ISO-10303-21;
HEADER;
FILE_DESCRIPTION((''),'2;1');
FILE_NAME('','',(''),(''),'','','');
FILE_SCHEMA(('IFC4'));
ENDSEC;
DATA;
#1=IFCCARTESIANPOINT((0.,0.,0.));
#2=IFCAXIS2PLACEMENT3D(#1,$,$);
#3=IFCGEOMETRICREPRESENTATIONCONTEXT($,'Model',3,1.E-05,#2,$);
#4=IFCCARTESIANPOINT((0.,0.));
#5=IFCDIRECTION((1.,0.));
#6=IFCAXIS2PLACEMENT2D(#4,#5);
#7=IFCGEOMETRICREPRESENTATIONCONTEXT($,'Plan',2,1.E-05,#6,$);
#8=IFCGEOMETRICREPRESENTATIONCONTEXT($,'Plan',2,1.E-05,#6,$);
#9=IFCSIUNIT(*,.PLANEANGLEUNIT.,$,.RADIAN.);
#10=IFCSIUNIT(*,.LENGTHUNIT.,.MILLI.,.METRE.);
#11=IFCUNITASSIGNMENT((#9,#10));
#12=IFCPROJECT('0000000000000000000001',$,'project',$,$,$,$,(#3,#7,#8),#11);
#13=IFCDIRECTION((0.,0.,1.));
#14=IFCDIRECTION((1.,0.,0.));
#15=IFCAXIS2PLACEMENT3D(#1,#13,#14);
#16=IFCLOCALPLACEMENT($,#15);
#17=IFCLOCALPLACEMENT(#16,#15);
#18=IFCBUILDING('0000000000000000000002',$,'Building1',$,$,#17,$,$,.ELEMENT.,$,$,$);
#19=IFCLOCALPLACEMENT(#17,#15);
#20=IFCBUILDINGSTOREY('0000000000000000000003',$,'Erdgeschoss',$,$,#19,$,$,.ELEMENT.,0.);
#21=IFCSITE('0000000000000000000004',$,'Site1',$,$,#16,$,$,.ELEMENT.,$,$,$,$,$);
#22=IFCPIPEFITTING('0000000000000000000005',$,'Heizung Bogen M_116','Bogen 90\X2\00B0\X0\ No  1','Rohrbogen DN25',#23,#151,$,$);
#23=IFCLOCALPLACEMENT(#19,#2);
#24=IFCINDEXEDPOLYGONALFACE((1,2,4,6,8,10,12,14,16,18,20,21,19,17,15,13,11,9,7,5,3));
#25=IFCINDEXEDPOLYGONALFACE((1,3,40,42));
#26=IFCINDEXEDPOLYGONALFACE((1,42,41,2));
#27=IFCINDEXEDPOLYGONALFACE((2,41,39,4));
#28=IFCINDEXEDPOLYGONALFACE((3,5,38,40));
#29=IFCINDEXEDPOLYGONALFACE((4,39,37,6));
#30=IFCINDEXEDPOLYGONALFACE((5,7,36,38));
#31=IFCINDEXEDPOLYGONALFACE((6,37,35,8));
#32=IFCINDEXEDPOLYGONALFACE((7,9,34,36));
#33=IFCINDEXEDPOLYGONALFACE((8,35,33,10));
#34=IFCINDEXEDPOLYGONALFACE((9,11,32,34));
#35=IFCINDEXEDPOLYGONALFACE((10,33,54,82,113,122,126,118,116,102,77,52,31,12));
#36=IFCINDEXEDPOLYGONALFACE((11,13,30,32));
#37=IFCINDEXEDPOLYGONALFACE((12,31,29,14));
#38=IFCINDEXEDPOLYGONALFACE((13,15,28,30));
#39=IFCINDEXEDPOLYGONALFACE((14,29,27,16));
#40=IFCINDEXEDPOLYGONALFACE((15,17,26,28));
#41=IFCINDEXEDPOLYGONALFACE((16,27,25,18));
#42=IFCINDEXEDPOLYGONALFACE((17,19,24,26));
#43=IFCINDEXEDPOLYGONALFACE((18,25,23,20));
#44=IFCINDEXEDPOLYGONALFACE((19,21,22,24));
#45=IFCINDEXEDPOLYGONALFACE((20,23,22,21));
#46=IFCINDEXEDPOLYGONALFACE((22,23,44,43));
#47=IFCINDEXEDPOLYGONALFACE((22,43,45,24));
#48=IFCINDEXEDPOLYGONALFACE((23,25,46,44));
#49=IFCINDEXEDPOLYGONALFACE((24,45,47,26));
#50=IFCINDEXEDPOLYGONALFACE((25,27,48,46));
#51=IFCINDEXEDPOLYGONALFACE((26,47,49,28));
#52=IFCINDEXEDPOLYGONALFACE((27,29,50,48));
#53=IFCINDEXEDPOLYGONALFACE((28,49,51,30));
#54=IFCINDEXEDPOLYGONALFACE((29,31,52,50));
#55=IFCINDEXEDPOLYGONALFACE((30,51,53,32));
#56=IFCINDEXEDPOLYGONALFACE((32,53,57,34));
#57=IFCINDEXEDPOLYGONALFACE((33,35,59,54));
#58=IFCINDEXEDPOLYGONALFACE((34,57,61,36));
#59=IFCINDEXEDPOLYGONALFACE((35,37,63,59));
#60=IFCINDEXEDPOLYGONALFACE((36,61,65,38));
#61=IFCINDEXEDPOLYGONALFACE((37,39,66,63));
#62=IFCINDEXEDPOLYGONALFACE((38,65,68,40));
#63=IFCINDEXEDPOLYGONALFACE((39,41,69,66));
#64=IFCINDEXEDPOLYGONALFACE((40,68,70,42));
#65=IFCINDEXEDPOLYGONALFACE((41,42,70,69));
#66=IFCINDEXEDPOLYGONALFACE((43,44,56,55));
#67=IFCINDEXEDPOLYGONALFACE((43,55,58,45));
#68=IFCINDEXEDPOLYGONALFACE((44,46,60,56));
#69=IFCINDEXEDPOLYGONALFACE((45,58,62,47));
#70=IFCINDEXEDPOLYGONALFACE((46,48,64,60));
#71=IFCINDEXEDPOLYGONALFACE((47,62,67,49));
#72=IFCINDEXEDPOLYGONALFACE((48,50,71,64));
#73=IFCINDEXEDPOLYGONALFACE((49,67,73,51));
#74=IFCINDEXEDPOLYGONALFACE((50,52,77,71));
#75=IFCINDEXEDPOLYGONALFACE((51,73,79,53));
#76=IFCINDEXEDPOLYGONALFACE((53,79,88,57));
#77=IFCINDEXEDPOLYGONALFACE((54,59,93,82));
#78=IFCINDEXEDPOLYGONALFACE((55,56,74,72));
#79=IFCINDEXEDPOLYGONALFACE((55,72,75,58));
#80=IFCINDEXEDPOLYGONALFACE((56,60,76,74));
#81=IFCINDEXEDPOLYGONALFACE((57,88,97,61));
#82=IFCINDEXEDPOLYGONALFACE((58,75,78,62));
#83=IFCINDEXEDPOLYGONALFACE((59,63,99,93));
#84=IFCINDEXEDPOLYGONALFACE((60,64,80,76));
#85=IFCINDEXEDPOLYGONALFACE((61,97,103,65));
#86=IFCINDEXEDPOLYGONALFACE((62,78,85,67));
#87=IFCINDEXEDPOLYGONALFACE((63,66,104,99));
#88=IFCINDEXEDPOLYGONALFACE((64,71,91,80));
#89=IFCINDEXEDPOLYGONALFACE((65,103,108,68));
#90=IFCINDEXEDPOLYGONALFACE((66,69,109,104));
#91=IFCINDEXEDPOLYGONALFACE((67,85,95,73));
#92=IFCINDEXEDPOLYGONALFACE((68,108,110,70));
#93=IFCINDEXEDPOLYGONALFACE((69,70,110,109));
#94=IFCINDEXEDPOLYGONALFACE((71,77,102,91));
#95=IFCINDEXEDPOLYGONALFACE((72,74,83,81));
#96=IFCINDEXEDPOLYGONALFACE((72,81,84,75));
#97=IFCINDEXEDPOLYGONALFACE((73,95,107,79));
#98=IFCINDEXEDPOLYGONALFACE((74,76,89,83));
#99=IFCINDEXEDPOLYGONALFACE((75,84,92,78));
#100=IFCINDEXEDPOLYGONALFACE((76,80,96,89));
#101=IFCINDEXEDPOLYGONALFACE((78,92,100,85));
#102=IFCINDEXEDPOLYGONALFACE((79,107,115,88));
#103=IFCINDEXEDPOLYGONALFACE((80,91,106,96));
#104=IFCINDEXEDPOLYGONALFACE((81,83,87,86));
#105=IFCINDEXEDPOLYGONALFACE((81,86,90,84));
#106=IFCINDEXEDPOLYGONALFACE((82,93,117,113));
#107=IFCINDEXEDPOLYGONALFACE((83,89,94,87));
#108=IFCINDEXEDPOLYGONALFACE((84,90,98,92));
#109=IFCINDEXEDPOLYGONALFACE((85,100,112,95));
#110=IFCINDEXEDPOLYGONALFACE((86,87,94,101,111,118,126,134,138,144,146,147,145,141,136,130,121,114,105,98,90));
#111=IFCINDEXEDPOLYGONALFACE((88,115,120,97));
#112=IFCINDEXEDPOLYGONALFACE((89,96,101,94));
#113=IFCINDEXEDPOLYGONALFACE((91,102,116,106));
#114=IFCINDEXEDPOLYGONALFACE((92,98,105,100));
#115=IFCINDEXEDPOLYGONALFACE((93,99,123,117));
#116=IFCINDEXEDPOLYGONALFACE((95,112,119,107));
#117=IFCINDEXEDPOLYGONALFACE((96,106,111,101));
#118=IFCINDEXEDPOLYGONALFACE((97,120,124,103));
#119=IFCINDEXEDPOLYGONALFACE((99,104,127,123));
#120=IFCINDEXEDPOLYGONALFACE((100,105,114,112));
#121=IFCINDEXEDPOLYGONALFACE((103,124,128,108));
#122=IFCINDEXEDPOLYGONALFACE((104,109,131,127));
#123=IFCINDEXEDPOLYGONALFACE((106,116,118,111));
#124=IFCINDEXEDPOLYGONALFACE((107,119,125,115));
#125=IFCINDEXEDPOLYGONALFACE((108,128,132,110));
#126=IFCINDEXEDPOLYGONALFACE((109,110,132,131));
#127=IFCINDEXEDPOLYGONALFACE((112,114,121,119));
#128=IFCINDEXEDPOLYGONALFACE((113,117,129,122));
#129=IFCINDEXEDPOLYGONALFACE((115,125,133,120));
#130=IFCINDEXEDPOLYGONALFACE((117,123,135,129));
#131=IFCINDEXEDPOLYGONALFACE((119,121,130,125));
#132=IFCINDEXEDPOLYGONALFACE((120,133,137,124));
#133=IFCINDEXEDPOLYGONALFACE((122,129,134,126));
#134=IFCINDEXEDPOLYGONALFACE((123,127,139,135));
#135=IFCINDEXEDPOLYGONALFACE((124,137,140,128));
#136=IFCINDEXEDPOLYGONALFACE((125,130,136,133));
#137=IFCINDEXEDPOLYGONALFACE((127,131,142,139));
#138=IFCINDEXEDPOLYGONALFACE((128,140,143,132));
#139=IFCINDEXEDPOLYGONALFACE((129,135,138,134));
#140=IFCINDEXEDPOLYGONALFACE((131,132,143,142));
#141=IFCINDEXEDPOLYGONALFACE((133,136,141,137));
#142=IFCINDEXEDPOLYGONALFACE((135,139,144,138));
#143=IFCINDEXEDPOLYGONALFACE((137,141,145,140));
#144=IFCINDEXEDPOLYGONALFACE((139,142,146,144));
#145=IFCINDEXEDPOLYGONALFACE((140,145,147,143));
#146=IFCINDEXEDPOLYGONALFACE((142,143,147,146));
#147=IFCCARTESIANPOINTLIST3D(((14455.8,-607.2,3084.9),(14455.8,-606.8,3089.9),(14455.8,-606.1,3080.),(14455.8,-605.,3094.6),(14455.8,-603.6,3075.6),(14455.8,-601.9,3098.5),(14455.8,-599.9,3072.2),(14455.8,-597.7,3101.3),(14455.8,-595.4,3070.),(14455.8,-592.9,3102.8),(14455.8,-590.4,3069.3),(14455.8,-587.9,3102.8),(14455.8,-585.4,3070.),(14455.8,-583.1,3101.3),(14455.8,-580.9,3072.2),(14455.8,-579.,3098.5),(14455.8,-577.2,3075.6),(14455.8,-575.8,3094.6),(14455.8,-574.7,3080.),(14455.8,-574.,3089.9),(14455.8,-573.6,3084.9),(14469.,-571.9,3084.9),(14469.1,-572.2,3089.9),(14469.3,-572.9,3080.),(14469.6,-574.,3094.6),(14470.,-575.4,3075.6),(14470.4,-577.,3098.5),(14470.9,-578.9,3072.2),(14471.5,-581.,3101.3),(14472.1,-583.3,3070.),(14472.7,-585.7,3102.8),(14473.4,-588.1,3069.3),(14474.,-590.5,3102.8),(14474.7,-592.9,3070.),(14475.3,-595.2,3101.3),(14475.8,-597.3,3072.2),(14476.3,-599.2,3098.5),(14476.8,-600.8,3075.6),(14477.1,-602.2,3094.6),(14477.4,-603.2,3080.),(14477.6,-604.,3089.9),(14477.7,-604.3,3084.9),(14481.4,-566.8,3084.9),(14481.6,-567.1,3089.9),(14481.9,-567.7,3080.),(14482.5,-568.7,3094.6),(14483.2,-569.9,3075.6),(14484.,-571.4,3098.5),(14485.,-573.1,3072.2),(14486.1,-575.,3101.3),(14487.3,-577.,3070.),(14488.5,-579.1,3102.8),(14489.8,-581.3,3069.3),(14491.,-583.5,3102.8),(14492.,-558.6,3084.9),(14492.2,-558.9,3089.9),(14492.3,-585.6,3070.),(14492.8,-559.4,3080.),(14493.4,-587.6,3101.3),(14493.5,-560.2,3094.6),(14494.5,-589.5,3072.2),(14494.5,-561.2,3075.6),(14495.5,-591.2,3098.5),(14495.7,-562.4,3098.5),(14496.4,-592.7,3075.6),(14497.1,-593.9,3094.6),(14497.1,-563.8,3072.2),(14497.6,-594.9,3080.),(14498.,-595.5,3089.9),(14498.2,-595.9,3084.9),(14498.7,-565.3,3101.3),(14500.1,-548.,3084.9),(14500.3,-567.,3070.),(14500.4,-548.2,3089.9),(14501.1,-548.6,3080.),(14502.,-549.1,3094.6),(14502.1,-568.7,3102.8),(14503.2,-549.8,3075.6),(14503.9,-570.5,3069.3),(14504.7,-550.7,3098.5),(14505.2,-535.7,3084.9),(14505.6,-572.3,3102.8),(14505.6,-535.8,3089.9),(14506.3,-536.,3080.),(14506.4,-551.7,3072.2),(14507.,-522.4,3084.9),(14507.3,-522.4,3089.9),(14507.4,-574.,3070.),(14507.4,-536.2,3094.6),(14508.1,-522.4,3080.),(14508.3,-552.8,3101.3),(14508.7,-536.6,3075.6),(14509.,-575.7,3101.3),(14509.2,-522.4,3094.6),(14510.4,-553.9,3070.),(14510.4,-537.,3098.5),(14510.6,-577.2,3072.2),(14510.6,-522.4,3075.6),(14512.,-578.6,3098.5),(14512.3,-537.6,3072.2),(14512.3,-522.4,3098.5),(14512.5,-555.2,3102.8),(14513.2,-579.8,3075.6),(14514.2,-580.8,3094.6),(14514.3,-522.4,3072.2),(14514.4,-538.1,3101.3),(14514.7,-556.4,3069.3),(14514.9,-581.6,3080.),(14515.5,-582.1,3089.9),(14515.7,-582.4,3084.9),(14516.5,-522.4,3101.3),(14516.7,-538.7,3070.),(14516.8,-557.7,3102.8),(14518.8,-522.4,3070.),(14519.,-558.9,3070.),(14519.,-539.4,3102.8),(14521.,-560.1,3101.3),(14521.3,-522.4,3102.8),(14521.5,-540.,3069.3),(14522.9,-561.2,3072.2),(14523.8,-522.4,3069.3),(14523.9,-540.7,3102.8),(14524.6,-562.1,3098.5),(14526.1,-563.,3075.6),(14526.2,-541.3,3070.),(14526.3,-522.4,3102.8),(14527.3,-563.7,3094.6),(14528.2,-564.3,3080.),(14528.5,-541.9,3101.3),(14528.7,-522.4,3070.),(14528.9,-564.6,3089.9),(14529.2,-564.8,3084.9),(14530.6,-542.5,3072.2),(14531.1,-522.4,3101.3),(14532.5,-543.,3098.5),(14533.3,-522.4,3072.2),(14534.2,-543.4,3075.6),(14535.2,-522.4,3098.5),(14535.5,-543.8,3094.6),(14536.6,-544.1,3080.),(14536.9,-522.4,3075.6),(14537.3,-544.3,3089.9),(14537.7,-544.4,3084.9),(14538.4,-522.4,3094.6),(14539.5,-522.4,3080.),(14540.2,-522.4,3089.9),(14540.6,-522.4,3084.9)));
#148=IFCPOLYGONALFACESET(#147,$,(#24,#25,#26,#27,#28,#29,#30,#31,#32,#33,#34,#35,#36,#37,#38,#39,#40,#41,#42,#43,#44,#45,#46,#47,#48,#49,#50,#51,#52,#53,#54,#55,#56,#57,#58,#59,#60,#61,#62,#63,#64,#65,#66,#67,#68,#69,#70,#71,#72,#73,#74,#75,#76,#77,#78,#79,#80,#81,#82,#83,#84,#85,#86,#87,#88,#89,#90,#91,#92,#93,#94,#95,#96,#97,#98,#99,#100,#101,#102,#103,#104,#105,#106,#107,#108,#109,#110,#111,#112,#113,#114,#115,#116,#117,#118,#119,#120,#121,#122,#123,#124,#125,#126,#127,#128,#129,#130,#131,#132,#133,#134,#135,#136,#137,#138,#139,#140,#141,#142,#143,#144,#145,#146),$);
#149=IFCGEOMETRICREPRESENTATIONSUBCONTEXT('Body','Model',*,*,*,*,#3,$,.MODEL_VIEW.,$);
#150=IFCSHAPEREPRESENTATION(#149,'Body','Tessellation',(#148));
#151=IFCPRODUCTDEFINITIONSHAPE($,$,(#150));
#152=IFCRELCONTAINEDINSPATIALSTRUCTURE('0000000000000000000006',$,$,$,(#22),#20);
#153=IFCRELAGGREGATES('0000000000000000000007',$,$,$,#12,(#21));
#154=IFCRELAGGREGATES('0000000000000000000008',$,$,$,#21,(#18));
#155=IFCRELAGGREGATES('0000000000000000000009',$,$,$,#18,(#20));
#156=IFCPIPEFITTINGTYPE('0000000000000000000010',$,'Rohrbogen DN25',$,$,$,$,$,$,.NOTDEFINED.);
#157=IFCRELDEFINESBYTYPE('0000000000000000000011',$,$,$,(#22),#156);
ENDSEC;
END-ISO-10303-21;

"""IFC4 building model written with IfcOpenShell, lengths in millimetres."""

from ifc_helpers import new_model, entity, si_unit, frame, origin, origin_with_axes, origin_2d_with_axis, place, context, subcontext, project, spatial, source, transform, mapped, type_object, element, save


model = new_model("IFC4")

# Units and contexts
model_context = context("Model", 3, precision=1e-05, world=origin())
plan_context_1 = context("Plan", 2, precision=1e-05, world=origin_2d_with_axis())
plan_context_2 = context("Plan", 2, precision=1e-05, world=origin_2d_with_axis())
body_context = subcontext(model_context, "Body", "Model", "MODEL_VIEW")
ifc_project = project(units=[si_unit("PLANEANGLEUNIT", "RADIAN"), si_unit("LENGTHUNIT", "METRE", prefix="MILLI")], contexts=[model_context, plan_context_1, plan_context_2])

# Site, building, storey
site_placement = place(None, origin_with_axes())
site = spatial("IfcSite", under=ifc_project, at=site_placement, Name="Site1", CompositionType="ELEMENT")
building_placement = place(site_placement, origin_with_axes())
building = spatial("IfcBuilding", under=site, at=building_placement, Name="Building1", CompositionType="ELEMENT")
storey_placement = place(building_placement, origin_with_axes())
storey = spatial("IfcBuildingStorey", under=building, at=storey_placement, Name="Erdgeschoss", CompositionType="ELEMENT", Elevation=0.0)

# Pipe fitting
pipe_fitting_type = type_object("IfcPipeFittingType", Name="Rohrbogen DN25", PredefinedType="NOTDEFINED")
shared_shape_1 = source(origin_with_axes(), body_context, "Body", "SolidModel", [
    entity("IfcRevolvedAreaSolid", entity("IfcCircleProfileDef", "AREA", None, entity("IfcAxis2Placement2D", entity("IfcCartesianPoint", [0.0, 0.0]), entity("IfcDirection", [1.0, 0.0])), 16.9), entity("IfcAxis2Placement3D", entity("IfcCartesianPoint", [-42.4, 25.6, 0.0]), entity("IfcDirection", [1.0, 0.0, 0.0]), entity("IfcDirection", [0.0, 0.0, 1.0])), entity("IfcAxis1Placement", entity("IfcCartesianPoint", [0.0, 68.0, 0.0]), entity("IfcDirection", [-1.0, 0.0, 0.0])), 1.570796),
])
pipe_fitting_1_placement = place(storey_placement, frame((14498.2, -564.8, 3086.1), z_axis=(0.0, 0.0, 1.0), x_axis=(1.0, 0.0, 0.0)))
element("IfcPipeFitting", 1, at=pipe_fitting_1_placement, inside=storey, type_object=pipe_fitting_type, Name="Heizung Bogen M_116", Description="Bogen 90° No  1", ObjectType="Rohrbogen DN25", context=body_context, shape_type="MappedRepresentation", body=[
    mapped(shared_shape_1, transform((0.0, 0.0, 0.0), x_axis=(1.0, 0.0, 0.0), y_axis=(0.0, -1.0, 0.0), z_axis=(0.0, 0.0, -1.0), scale=1.0)),
])

save(model, "model.ifc")
